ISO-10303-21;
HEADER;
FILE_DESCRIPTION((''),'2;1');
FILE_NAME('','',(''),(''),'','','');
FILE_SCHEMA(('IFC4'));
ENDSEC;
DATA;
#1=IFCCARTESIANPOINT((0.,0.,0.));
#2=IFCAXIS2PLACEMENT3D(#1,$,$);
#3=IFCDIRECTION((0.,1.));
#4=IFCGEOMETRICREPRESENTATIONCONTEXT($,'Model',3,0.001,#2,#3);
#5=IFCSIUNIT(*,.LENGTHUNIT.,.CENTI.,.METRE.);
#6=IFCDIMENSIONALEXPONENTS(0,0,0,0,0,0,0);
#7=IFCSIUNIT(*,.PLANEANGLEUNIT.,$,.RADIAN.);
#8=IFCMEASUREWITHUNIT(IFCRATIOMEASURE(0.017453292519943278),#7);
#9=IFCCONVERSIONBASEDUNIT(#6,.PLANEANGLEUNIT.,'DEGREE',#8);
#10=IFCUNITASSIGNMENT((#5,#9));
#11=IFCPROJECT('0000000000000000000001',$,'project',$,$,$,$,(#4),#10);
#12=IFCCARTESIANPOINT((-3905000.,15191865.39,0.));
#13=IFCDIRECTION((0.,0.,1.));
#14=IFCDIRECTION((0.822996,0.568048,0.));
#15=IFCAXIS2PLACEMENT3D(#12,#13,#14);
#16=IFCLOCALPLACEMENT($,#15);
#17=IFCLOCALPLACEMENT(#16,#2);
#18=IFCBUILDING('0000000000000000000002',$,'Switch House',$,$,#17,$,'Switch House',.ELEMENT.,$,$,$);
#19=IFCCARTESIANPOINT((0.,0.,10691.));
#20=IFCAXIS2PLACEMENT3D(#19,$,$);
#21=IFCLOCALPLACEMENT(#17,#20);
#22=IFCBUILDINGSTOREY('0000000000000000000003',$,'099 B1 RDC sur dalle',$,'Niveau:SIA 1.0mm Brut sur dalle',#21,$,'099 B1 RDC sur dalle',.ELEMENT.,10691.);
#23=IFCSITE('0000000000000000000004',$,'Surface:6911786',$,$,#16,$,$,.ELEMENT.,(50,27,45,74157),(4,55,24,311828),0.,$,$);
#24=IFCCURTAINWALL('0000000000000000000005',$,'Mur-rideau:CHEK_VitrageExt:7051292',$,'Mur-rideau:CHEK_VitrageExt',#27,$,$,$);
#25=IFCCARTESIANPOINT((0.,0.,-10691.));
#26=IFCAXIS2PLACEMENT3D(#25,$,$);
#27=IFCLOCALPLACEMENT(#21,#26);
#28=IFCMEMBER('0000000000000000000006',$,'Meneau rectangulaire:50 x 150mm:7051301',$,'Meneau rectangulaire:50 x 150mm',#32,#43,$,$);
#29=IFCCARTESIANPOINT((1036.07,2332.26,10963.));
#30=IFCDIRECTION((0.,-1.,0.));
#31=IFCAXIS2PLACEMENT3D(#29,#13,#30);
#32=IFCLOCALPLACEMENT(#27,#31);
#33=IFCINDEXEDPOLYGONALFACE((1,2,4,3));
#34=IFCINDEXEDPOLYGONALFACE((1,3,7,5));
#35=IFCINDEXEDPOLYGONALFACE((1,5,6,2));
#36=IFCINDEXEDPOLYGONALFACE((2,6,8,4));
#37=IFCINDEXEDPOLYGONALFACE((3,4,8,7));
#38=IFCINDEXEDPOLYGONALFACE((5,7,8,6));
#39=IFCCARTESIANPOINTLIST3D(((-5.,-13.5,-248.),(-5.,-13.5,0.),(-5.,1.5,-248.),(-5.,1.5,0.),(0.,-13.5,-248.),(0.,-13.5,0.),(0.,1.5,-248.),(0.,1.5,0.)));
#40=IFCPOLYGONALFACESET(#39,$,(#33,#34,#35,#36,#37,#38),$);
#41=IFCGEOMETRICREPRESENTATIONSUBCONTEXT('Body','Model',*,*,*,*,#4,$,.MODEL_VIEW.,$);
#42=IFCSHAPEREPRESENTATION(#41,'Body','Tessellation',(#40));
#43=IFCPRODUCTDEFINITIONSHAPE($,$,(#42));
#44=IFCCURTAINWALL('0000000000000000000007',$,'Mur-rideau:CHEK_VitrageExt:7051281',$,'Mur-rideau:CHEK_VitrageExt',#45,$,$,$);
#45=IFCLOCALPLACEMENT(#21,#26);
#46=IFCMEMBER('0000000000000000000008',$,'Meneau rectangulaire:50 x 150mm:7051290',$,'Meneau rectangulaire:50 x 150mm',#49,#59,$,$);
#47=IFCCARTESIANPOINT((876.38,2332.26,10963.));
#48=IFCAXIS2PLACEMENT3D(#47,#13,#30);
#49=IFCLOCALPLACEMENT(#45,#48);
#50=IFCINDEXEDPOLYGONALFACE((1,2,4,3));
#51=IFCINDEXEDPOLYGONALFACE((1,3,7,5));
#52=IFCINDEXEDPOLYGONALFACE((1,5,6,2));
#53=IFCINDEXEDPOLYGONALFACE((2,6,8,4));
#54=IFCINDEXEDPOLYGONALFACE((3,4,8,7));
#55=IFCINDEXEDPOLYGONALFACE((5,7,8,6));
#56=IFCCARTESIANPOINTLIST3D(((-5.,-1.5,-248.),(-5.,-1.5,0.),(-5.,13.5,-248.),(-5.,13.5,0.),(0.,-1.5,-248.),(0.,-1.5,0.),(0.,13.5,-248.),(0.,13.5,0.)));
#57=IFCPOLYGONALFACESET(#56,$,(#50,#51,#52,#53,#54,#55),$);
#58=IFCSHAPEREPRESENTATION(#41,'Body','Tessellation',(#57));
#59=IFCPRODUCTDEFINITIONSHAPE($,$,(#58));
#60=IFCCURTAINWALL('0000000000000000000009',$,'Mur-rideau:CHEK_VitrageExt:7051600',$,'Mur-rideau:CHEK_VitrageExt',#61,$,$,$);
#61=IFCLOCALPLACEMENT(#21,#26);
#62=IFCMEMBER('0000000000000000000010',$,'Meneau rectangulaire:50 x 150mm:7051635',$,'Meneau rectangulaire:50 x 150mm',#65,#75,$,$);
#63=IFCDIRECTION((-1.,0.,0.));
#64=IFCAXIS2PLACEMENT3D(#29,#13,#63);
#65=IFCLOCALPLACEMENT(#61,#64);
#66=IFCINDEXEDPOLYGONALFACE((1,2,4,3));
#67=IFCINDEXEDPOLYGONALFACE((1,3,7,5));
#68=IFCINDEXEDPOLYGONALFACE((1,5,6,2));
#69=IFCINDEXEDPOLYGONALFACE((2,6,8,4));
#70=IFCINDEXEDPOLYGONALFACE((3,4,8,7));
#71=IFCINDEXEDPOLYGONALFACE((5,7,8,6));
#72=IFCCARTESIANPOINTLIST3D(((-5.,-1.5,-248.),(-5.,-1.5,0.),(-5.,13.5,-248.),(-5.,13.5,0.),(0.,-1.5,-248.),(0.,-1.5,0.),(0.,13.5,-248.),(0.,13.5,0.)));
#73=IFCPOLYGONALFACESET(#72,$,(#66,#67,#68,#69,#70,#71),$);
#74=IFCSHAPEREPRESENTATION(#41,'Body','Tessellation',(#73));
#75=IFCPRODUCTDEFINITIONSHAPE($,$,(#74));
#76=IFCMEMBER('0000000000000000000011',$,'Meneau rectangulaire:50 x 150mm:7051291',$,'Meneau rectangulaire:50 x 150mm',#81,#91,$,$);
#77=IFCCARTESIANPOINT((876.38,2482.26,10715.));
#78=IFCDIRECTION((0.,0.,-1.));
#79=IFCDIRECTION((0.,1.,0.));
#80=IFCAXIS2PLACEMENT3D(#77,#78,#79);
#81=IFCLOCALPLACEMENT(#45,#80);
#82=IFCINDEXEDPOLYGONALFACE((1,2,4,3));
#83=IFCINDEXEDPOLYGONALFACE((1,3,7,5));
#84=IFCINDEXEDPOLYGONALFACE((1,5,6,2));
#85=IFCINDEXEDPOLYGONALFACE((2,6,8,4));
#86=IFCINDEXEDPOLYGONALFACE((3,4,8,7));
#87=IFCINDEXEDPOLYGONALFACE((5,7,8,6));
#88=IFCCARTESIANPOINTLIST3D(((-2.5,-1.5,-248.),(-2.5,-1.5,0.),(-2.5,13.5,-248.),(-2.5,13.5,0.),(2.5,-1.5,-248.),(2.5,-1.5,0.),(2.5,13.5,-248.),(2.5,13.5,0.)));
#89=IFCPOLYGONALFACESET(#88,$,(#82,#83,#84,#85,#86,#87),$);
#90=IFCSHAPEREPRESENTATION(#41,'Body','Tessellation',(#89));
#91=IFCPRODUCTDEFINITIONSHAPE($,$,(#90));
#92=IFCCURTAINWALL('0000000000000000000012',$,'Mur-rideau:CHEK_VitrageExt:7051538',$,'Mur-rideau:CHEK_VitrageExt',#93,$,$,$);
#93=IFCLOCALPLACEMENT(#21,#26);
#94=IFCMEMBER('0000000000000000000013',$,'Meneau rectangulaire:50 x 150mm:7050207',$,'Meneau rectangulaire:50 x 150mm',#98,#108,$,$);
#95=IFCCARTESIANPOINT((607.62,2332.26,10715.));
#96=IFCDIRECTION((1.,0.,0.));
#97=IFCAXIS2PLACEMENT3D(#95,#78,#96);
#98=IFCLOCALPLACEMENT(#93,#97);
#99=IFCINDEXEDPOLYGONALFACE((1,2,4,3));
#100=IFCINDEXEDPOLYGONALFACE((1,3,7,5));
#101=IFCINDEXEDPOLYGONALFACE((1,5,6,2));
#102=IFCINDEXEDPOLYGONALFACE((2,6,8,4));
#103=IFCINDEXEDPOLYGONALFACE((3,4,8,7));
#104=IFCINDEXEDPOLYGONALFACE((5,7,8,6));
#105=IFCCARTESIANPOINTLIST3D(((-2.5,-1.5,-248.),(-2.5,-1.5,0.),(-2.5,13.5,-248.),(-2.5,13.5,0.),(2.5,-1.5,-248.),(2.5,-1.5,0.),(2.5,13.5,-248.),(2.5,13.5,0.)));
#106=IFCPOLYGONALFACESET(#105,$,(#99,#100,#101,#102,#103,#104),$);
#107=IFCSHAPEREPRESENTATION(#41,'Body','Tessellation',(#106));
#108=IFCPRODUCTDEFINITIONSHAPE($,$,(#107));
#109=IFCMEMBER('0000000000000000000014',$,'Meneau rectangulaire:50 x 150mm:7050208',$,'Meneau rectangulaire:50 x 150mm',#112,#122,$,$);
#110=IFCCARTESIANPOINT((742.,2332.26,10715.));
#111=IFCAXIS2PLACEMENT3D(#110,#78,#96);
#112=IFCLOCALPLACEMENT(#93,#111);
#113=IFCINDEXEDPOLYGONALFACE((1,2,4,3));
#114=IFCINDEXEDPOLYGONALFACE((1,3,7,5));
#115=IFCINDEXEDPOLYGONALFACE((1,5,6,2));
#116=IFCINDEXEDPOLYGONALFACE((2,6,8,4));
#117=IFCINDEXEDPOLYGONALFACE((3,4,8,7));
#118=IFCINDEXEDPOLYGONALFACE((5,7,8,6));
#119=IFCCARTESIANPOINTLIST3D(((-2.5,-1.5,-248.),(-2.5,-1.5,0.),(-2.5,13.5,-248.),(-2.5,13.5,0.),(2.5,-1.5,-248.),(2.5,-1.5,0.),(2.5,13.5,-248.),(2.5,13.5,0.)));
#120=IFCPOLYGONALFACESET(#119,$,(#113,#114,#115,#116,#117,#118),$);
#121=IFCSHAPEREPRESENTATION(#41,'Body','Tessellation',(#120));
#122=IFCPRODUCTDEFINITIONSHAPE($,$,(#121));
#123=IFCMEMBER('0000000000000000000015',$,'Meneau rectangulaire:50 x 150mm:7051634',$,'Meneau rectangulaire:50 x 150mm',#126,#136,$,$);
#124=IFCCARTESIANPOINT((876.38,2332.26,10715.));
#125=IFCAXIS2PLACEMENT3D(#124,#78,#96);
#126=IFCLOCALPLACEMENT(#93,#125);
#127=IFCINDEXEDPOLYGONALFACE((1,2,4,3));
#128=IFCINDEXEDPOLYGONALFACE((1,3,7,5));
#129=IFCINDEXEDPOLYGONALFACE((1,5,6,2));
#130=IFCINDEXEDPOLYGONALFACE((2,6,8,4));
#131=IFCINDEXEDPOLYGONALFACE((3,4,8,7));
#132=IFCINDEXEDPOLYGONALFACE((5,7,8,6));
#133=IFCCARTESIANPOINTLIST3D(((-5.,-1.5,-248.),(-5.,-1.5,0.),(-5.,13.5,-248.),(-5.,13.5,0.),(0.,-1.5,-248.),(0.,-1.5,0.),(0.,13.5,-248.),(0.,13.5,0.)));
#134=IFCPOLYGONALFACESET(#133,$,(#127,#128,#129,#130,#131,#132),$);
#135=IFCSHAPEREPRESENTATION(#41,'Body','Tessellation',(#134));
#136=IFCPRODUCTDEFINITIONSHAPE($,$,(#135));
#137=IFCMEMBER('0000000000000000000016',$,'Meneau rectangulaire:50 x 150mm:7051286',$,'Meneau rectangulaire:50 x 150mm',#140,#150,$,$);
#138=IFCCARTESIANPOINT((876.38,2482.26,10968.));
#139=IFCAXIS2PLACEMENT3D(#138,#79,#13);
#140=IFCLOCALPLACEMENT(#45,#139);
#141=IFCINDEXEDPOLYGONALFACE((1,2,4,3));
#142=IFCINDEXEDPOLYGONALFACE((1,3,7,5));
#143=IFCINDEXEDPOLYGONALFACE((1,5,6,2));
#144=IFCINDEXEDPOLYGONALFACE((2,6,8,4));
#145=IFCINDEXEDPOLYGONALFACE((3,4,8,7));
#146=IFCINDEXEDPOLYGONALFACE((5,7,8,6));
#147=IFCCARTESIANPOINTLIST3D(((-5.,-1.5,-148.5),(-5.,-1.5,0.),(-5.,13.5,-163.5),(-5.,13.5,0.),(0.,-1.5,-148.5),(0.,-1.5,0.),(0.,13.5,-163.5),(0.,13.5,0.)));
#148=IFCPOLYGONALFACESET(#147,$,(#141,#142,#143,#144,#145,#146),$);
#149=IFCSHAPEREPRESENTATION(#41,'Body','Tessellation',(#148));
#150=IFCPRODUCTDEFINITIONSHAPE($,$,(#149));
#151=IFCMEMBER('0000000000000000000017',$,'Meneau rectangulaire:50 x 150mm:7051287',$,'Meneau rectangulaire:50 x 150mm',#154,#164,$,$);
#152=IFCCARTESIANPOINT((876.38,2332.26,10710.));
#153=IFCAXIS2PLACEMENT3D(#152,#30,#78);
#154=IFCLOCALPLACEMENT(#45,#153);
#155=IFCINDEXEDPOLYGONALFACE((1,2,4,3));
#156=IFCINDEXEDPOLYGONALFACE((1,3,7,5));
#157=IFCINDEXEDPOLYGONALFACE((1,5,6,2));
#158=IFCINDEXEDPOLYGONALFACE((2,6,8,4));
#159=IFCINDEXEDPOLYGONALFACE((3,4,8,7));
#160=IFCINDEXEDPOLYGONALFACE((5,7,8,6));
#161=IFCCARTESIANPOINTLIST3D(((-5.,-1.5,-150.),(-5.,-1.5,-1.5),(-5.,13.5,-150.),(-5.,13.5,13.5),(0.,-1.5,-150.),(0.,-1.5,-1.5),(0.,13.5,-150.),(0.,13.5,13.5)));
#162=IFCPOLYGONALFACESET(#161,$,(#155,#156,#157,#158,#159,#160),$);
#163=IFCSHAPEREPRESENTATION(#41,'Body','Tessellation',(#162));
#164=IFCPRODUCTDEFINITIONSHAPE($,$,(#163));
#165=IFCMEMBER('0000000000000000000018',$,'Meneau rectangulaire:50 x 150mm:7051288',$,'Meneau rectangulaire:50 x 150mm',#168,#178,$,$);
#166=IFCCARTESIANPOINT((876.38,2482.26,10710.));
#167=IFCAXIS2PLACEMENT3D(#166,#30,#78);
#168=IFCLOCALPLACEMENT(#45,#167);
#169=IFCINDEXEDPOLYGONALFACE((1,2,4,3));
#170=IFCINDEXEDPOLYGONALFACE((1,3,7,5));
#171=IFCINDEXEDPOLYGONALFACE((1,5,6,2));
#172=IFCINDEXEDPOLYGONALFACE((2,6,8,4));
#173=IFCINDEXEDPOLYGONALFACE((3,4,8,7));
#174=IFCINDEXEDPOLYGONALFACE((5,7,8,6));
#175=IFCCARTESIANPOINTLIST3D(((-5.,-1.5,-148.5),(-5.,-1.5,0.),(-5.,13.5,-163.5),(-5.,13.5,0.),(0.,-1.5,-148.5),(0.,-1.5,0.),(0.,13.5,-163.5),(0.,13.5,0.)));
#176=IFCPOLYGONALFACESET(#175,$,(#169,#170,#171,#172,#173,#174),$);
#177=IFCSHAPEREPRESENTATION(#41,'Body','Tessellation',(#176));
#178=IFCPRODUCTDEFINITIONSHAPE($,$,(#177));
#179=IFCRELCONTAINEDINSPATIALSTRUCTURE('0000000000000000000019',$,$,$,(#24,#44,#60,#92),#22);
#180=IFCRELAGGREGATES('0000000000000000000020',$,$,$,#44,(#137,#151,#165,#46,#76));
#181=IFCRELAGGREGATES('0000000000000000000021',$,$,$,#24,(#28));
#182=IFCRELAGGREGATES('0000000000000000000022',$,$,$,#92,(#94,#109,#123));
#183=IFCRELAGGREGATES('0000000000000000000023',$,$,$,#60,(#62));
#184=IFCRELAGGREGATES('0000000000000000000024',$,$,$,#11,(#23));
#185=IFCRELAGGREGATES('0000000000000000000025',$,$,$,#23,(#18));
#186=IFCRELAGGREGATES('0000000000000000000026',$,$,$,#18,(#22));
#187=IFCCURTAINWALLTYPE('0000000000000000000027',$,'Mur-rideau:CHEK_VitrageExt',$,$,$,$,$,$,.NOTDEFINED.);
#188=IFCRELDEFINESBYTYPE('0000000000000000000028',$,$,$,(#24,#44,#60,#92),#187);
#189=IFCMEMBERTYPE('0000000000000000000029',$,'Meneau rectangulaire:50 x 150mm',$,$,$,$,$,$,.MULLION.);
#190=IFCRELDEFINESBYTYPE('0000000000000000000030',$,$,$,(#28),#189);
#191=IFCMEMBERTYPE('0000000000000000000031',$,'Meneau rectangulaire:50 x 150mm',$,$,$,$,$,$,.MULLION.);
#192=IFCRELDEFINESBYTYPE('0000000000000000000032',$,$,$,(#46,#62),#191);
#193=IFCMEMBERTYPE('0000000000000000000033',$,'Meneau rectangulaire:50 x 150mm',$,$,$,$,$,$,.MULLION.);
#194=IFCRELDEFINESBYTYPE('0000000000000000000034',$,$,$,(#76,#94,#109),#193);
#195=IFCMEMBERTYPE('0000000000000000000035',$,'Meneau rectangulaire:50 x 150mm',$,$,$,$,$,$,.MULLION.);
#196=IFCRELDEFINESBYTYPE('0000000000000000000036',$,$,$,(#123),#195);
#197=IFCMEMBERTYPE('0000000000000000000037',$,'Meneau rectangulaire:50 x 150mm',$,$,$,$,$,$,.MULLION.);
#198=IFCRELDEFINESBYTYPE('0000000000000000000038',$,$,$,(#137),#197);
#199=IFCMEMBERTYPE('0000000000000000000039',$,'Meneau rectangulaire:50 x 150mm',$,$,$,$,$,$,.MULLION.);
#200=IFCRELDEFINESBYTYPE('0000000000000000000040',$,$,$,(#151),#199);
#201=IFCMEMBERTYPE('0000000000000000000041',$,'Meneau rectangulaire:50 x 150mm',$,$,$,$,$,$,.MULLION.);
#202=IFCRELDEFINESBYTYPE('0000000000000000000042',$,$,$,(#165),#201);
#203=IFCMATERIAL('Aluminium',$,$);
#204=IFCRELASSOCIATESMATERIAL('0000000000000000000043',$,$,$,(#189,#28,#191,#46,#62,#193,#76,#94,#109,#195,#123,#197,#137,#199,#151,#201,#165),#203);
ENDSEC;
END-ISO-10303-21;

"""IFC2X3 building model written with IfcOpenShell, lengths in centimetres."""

from ifc_helpers import new_model, entity, si_unit, converted_unit, direction, frame, origin, origin_2d_with_axis, place, context, subcontext, project, spatial, rectangle, extrude, clip, halfspace, source, transform, mapped, material, type_object, type_shapes, element, aggregate, save


model = new_model("IFC2X3")

# Units and contexts
model_context = context("Model", 3, precision=0.001, world=origin(), true_north=direction((0.0, 1.0)))
body_context = subcontext(model_context, "Body", "Model", "MODEL_VIEW")
ifc_project = project(units=[si_unit("LENGTHUNIT", "METRE", prefix="CENTI"), converted_unit("PLANEANGLEUNIT", "DEGREE", entity("IfcRatioMeasure", 0.017453292519943278), si_unit("PLANEANGLEUNIT", "RADIAN"), dimensions=[0, 0, 0, 0, 0, 0, 0])], contexts=[model_context])

# Site, building, storey
site_placement = place(None, frame((-3905000.0, 15191865.39, 0.0), z_axis=(0.0, 0.0, 1.0), x_axis=(0.822996, 0.568048, 0.0)))
site = spatial("IfcSite", under=ifc_project, at=site_placement, Name="Surface:6911786", CompositionType="ELEMENT", RefLatitude=(50, 27, 45, 74157), RefLongitude=(4, 55, 24, 311828), RefElevation=0.0)
building_placement = place(site_placement, origin())
building = spatial("IfcBuilding", under=site, at=building_placement, Name="Switch House", LongName="Switch House", CompositionType="ELEMENT")
storey_placement = place(building_placement, frame((0.0, 0.0, 10691.0)))
storey = spatial("IfcBuildingStorey", under=building, at=storey_placement, Name="099 B1 RDC sur dalle", ObjectType="Niveau:SIA 1.0mm Brut sur dalle", LongName="099 B1 RDC sur dalle", CompositionType="ELEMENT", Elevation=10691.0)

# Curtain walls, members
curtain_wall_type = type_object("IfcCurtainWallType", Name="Mur-rideau:CHEK_VitrageExt", PredefinedType="NOTDEFINED")
curtain_wall_1_placement = place(storey_placement, frame((0.0, 0.0, -10691.0)))
curtain_wall_1 = element("IfcCurtainWall", 1, at=curtain_wall_1_placement, inside=storey, type_object=curtain_wall_type, Name="Mur-rideau:CHEK_VitrageExt:7051292", ObjectType="Mur-rideau:CHEK_VitrageExt")
ifc_material_1 = material(Name="Aluminium")
member_type_1 = type_object("IfcMemberType", Name="Meneau rectangulaire:50 x 150mm", PredefinedType="MULLION", material=ifc_material_1)
shared_shape_1 = source(origin(), body_context, "Body", "SweptSolid", [
    extrude(rectangle(XDim=15.0, YDim=5.0, at=origin_2d_with_axis()), frame((-2.5, -6.0, -248.0), z_axis=(0.0, 0.0, 1.0), x_axis=(0.0, -1.0, 0.0)), (0.0, 0.0, 1.0), 248.0),
])
type_shapes(member_type_1, [shared_shape_1])
member_1_placement = place(curtain_wall_1_placement, frame((1036.07, 2332.26, 10963.0), z_axis=(0.0, 0.0, 1.0), x_axis=(0.0, -1.0, 0.0)))
member_1 = element("IfcMember", 2, at=member_1_placement, type_object=member_type_1, material=ifc_material_1, Name="Meneau rectangulaire:50 x 150mm:7051301", ObjectType="Meneau rectangulaire:50 x 150mm", context=body_context, shape_type="MappedRepresentation", body=[
    mapped(shared_shape_1, transform((0.0, 0.0, 0.0), scale=1.0)),
])
curtain_wall_2_placement = place(storey_placement, frame((0.0, 0.0, -10691.0)))
curtain_wall_2 = element("IfcCurtainWall", 3, at=curtain_wall_2_placement, inside=storey, type_object=curtain_wall_type, Name="Mur-rideau:CHEK_VitrageExt:7051281", ObjectType="Mur-rideau:CHEK_VitrageExt")
member_type_2 = type_object("IfcMemberType", Name="Meneau rectangulaire:50 x 150mm", PredefinedType="MULLION", material=ifc_material_1)
shared_shape_2 = source(origin(), body_context, "Body", "SweptSolid", [
    extrude(rectangle(XDim=15.0, YDim=5.0, at=origin_2d_with_axis()), frame((-2.5, 6.0, -248.0), z_axis=(0.0, 0.0, 1.0), x_axis=(0.0, -1.0, 0.0)), (0.0, 0.0, 1.0), 248.0),
])
type_shapes(member_type_2, [shared_shape_2])
member_2_placement = place(curtain_wall_2_placement, frame((876.38, 2332.26, 10963.0), z_axis=(0.0, 0.0, 1.0), x_axis=(0.0, -1.0, 0.0)))
member_2 = element("IfcMember", 4, at=member_2_placement, type_object=member_type_2, material=ifc_material_1, Name="Meneau rectangulaire:50 x 150mm:7051290", ObjectType="Meneau rectangulaire:50 x 150mm", context=body_context, shape_type="MappedRepresentation", body=[
    mapped(shared_shape_2, transform((0.0, 0.0, 0.0), scale=1.0)),
])
curtain_wall_3_placement = place(storey_placement, frame((0.0, 0.0, -10691.0)))
curtain_wall_3 = element("IfcCurtainWall", 5, at=curtain_wall_3_placement, inside=storey, type_object=curtain_wall_type, Name="Mur-rideau:CHEK_VitrageExt:7051600", ObjectType="Mur-rideau:CHEK_VitrageExt")
member_3_placement = place(curtain_wall_3_placement, frame((1036.07, 2332.26, 10963.0), z_axis=(0.0, 0.0, 1.0), x_axis=(-1.0, 0.0, 0.0)))
member_3 = element("IfcMember", 6, at=member_3_placement, type_object=member_type_2, material=ifc_material_1, Name="Meneau rectangulaire:50 x 150mm:7051635", ObjectType="Meneau rectangulaire:50 x 150mm", context=body_context, shape_type="MappedRepresentation", body=[
    mapped(shared_shape_2, transform((0.0, 0.0, 0.0), scale=1.0)),
])

# Member
member_type_3 = type_object("IfcMemberType", Name="Meneau rectangulaire:50 x 150mm", PredefinedType="MULLION", material=ifc_material_1)
shared_shape_3 = source(origin(), body_context, "Body", "SweptSolid", [
    extrude(rectangle(XDim=15.0, YDim=5.0, at=origin_2d_with_axis()), frame((0.0, 6.0, -248.0), z_axis=(0.0, 0.0, 1.0), x_axis=(0.0, -1.0, 0.0)), (0.0, 0.0, 1.0), 248.0),
])
type_shapes(member_type_3, [shared_shape_3])
member_4_placement = place(curtain_wall_2_placement, frame((876.38, 2482.26, 10715.0), z_axis=(0.0, 0.0, -1.0), x_axis=(0.0, 1.0, 0.0)))
member_4 = element("IfcMember", 7, at=member_4_placement, type_object=member_type_3, material=ifc_material_1, Name="Meneau rectangulaire:50 x 150mm:7051291", ObjectType="Meneau rectangulaire:50 x 150mm", context=body_context, shape_type="MappedRepresentation", body=[
    mapped(shared_shape_3, transform((0.0, 0.0, 0.0), scale=1.0)),
])

# Curtain wall, members
curtain_wall_4_placement = place(storey_placement, frame((0.0, 0.0, -10691.0)))
curtain_wall_4 = element("IfcCurtainWall", 8, at=curtain_wall_4_placement, inside=storey, type_object=curtain_wall_type, Name="Mur-rideau:CHEK_VitrageExt:7051538", ObjectType="Mur-rideau:CHEK_VitrageExt")
member_5_placement = place(curtain_wall_4_placement, frame((607.62, 2332.26, 10715.0), z_axis=(0.0, 0.0, -1.0), x_axis=(1.0, 0.0, 0.0)))
member_5 = element("IfcMember", 9, at=member_5_placement, type_object=member_type_3, material=ifc_material_1, Name="Meneau rectangulaire:50 x 150mm:7050207", ObjectType="Meneau rectangulaire:50 x 150mm", context=body_context, shape_type="MappedRepresentation", body=[
    mapped(shared_shape_3, transform((0.0, 0.0, 0.0), scale=1.0)),
])
member_6_placement = place(curtain_wall_4_placement, frame((742.0, 2332.26, 10715.0), z_axis=(0.0, 0.0, -1.0), x_axis=(1.0, 0.0, 0.0)))
member_6 = element("IfcMember", 10, at=member_6_placement, type_object=member_type_3, material=ifc_material_1, Name="Meneau rectangulaire:50 x 150mm:7050208", ObjectType="Meneau rectangulaire:50 x 150mm", context=body_context, shape_type="MappedRepresentation", body=[
    mapped(shared_shape_3, transform((0.0, 0.0, 0.0), scale=1.0)),
])
member_type_4 = type_object("IfcMemberType", Name="Meneau rectangulaire:50 x 150mm", PredefinedType="MULLION", material=ifc_material_1)
shared_shape_4 = source(origin(), body_context, "Body", "SweptSolid", [
    extrude(rectangle(XDim=15.0, YDim=5.0, at=origin_2d_with_axis()), frame((-2.5, 6.0, -248.0), z_axis=(0.0, 0.0, 1.0), x_axis=(0.0, -1.0, 0.0)), (0.0, 0.0, 1.0), 248.0),
])
type_shapes(member_type_4, [shared_shape_4])
member_7_placement = place(curtain_wall_4_placement, frame((876.38, 2332.26, 10715.0), z_axis=(0.0, 0.0, -1.0), x_axis=(1.0, 0.0, 0.0)))
member_7 = element("IfcMember", 11, at=member_7_placement, type_object=member_type_4, material=ifc_material_1, Name="Meneau rectangulaire:50 x 150mm:7051634", ObjectType="Meneau rectangulaire:50 x 150mm", context=body_context, shape_type="MappedRepresentation", body=[
    mapped(shared_shape_4, transform((0.0, 0.0, 0.0), scale=1.0)),
])

# Members
member_type_5 = type_object("IfcMemberType", Name="Meneau rectangulaire:50 x 150mm", PredefinedType="MULLION", material=ifc_material_1)
shared_shape_5 = source(origin(), body_context, "Body", "SweptSolid", [
    clip(extrude(rectangle(XDim=15.0, YDim=5.0, at=origin_2d_with_axis()), frame((-2.5, 6.0, -163.5), z_axis=(0.0, 0.0, 1.0), x_axis=(0.0, -1.0, 0.0)), (0.0, 0.0, 1.0), 163.5), halfspace(frame((30.48, 0.0, -150.0), z_axis=(0.0, -0.707107, -0.707107), x_axis=(0.0, -0.707107, 0.707107)), False)),
])
type_shapes(member_type_5, [shared_shape_5])
member_8_placement = place(curtain_wall_2_placement, frame((876.38, 2482.26, 10968.0), z_axis=(0.0, 1.0, 0.0), x_axis=(0.0, 0.0, 1.0)))
member_8 = element("IfcMember", 12, at=member_8_placement, type_object=member_type_5, material=ifc_material_1, Name="Meneau rectangulaire:50 x 150mm:7051286", ObjectType="Meneau rectangulaire:50 x 150mm", context=body_context, shape_type="MappedRepresentation", body=[
    mapped(shared_shape_5, transform((0.0, 0.0, 0.0), scale=1.0)),
])
member_type_6 = type_object("IfcMemberType", Name="Meneau rectangulaire:50 x 150mm", PredefinedType="MULLION", material=ifc_material_1)
shared_shape_6 = source(origin(), body_context, "Body", "SweptSolid", [
    clip(extrude(rectangle(XDim=15.0, YDim=5.0, at=origin_2d_with_axis()), frame((-2.5, 6.0, -150.0), z_axis=(0.0, 0.0, 1.0), x_axis=(0.0, -1.0, 0.0)), (0.0, 0.0, 1.0), 163.5), halfspace(frame((30.48, 0.0, 0.0), z_axis=(0.0, -0.707107, 0.707107), x_axis=(0.0, -0.707107, -0.707107)), False)),
])
type_shapes(member_type_6, [shared_shape_6])
member_9_placement = place(curtain_wall_2_placement, frame((876.38, 2332.26, 10710.0), z_axis=(0.0, -1.0, 0.0), x_axis=(0.0, 0.0, -1.0)))
member_9 = element("IfcMember", 13, at=member_9_placement, type_object=member_type_6, material=ifc_material_1, Name="Meneau rectangulaire:50 x 150mm:7051287", ObjectType="Meneau rectangulaire:50 x 150mm", context=body_context, shape_type="MappedRepresentation", body=[
    mapped(shared_shape_6, transform((0.0, 0.0, 0.0), scale=1.0)),
])
member_type_7 = type_object("IfcMemberType", Name="Meneau rectangulaire:50 x 150mm", PredefinedType="MULLION", material=ifc_material_1)
shared_shape_7 = source(origin(), body_context, "Body", "SweptSolid", [
    clip(extrude(rectangle(XDim=15.0, YDim=5.0, at=origin_2d_with_axis()), frame((-2.5, 6.0, -163.5), z_axis=(0.0, 0.0, 1.0), x_axis=(0.0, -1.0, 0.0)), (0.0, 0.0, 1.0), 163.5), halfspace(frame((30.48, 0.0, -150.0), z_axis=(0.0, -0.707107, -0.707107), x_axis=(0.0, -0.707107, 0.707107)), False)),
])
type_shapes(member_type_7, [shared_shape_7])
member_10_placement = place(curtain_wall_2_placement, frame((876.38, 2482.26, 10710.0), z_axis=(0.0, -1.0, 0.0), x_axis=(0.0, 0.0, -1.0)))
member_10 = element("IfcMember", 14, at=member_10_placement, type_object=member_type_7, material=ifc_material_1, Name="Meneau rectangulaire:50 x 150mm:7051288", ObjectType="Meneau rectangulaire:50 x 150mm", context=body_context, shape_type="MappedRepresentation", body=[
    mapped(shared_shape_7, transform((0.0, 0.0, 0.0), scale=1.0)),
])

aggregate(curtain_wall_2, [member_8, member_9, member_10, member_2, member_4])
aggregate(curtain_wall_1, [member_1])
aggregate(curtain_wall_4, [member_5, member_6, member_7])
aggregate(curtain_wall_3, [member_3])

save(model, "model.ifc")
